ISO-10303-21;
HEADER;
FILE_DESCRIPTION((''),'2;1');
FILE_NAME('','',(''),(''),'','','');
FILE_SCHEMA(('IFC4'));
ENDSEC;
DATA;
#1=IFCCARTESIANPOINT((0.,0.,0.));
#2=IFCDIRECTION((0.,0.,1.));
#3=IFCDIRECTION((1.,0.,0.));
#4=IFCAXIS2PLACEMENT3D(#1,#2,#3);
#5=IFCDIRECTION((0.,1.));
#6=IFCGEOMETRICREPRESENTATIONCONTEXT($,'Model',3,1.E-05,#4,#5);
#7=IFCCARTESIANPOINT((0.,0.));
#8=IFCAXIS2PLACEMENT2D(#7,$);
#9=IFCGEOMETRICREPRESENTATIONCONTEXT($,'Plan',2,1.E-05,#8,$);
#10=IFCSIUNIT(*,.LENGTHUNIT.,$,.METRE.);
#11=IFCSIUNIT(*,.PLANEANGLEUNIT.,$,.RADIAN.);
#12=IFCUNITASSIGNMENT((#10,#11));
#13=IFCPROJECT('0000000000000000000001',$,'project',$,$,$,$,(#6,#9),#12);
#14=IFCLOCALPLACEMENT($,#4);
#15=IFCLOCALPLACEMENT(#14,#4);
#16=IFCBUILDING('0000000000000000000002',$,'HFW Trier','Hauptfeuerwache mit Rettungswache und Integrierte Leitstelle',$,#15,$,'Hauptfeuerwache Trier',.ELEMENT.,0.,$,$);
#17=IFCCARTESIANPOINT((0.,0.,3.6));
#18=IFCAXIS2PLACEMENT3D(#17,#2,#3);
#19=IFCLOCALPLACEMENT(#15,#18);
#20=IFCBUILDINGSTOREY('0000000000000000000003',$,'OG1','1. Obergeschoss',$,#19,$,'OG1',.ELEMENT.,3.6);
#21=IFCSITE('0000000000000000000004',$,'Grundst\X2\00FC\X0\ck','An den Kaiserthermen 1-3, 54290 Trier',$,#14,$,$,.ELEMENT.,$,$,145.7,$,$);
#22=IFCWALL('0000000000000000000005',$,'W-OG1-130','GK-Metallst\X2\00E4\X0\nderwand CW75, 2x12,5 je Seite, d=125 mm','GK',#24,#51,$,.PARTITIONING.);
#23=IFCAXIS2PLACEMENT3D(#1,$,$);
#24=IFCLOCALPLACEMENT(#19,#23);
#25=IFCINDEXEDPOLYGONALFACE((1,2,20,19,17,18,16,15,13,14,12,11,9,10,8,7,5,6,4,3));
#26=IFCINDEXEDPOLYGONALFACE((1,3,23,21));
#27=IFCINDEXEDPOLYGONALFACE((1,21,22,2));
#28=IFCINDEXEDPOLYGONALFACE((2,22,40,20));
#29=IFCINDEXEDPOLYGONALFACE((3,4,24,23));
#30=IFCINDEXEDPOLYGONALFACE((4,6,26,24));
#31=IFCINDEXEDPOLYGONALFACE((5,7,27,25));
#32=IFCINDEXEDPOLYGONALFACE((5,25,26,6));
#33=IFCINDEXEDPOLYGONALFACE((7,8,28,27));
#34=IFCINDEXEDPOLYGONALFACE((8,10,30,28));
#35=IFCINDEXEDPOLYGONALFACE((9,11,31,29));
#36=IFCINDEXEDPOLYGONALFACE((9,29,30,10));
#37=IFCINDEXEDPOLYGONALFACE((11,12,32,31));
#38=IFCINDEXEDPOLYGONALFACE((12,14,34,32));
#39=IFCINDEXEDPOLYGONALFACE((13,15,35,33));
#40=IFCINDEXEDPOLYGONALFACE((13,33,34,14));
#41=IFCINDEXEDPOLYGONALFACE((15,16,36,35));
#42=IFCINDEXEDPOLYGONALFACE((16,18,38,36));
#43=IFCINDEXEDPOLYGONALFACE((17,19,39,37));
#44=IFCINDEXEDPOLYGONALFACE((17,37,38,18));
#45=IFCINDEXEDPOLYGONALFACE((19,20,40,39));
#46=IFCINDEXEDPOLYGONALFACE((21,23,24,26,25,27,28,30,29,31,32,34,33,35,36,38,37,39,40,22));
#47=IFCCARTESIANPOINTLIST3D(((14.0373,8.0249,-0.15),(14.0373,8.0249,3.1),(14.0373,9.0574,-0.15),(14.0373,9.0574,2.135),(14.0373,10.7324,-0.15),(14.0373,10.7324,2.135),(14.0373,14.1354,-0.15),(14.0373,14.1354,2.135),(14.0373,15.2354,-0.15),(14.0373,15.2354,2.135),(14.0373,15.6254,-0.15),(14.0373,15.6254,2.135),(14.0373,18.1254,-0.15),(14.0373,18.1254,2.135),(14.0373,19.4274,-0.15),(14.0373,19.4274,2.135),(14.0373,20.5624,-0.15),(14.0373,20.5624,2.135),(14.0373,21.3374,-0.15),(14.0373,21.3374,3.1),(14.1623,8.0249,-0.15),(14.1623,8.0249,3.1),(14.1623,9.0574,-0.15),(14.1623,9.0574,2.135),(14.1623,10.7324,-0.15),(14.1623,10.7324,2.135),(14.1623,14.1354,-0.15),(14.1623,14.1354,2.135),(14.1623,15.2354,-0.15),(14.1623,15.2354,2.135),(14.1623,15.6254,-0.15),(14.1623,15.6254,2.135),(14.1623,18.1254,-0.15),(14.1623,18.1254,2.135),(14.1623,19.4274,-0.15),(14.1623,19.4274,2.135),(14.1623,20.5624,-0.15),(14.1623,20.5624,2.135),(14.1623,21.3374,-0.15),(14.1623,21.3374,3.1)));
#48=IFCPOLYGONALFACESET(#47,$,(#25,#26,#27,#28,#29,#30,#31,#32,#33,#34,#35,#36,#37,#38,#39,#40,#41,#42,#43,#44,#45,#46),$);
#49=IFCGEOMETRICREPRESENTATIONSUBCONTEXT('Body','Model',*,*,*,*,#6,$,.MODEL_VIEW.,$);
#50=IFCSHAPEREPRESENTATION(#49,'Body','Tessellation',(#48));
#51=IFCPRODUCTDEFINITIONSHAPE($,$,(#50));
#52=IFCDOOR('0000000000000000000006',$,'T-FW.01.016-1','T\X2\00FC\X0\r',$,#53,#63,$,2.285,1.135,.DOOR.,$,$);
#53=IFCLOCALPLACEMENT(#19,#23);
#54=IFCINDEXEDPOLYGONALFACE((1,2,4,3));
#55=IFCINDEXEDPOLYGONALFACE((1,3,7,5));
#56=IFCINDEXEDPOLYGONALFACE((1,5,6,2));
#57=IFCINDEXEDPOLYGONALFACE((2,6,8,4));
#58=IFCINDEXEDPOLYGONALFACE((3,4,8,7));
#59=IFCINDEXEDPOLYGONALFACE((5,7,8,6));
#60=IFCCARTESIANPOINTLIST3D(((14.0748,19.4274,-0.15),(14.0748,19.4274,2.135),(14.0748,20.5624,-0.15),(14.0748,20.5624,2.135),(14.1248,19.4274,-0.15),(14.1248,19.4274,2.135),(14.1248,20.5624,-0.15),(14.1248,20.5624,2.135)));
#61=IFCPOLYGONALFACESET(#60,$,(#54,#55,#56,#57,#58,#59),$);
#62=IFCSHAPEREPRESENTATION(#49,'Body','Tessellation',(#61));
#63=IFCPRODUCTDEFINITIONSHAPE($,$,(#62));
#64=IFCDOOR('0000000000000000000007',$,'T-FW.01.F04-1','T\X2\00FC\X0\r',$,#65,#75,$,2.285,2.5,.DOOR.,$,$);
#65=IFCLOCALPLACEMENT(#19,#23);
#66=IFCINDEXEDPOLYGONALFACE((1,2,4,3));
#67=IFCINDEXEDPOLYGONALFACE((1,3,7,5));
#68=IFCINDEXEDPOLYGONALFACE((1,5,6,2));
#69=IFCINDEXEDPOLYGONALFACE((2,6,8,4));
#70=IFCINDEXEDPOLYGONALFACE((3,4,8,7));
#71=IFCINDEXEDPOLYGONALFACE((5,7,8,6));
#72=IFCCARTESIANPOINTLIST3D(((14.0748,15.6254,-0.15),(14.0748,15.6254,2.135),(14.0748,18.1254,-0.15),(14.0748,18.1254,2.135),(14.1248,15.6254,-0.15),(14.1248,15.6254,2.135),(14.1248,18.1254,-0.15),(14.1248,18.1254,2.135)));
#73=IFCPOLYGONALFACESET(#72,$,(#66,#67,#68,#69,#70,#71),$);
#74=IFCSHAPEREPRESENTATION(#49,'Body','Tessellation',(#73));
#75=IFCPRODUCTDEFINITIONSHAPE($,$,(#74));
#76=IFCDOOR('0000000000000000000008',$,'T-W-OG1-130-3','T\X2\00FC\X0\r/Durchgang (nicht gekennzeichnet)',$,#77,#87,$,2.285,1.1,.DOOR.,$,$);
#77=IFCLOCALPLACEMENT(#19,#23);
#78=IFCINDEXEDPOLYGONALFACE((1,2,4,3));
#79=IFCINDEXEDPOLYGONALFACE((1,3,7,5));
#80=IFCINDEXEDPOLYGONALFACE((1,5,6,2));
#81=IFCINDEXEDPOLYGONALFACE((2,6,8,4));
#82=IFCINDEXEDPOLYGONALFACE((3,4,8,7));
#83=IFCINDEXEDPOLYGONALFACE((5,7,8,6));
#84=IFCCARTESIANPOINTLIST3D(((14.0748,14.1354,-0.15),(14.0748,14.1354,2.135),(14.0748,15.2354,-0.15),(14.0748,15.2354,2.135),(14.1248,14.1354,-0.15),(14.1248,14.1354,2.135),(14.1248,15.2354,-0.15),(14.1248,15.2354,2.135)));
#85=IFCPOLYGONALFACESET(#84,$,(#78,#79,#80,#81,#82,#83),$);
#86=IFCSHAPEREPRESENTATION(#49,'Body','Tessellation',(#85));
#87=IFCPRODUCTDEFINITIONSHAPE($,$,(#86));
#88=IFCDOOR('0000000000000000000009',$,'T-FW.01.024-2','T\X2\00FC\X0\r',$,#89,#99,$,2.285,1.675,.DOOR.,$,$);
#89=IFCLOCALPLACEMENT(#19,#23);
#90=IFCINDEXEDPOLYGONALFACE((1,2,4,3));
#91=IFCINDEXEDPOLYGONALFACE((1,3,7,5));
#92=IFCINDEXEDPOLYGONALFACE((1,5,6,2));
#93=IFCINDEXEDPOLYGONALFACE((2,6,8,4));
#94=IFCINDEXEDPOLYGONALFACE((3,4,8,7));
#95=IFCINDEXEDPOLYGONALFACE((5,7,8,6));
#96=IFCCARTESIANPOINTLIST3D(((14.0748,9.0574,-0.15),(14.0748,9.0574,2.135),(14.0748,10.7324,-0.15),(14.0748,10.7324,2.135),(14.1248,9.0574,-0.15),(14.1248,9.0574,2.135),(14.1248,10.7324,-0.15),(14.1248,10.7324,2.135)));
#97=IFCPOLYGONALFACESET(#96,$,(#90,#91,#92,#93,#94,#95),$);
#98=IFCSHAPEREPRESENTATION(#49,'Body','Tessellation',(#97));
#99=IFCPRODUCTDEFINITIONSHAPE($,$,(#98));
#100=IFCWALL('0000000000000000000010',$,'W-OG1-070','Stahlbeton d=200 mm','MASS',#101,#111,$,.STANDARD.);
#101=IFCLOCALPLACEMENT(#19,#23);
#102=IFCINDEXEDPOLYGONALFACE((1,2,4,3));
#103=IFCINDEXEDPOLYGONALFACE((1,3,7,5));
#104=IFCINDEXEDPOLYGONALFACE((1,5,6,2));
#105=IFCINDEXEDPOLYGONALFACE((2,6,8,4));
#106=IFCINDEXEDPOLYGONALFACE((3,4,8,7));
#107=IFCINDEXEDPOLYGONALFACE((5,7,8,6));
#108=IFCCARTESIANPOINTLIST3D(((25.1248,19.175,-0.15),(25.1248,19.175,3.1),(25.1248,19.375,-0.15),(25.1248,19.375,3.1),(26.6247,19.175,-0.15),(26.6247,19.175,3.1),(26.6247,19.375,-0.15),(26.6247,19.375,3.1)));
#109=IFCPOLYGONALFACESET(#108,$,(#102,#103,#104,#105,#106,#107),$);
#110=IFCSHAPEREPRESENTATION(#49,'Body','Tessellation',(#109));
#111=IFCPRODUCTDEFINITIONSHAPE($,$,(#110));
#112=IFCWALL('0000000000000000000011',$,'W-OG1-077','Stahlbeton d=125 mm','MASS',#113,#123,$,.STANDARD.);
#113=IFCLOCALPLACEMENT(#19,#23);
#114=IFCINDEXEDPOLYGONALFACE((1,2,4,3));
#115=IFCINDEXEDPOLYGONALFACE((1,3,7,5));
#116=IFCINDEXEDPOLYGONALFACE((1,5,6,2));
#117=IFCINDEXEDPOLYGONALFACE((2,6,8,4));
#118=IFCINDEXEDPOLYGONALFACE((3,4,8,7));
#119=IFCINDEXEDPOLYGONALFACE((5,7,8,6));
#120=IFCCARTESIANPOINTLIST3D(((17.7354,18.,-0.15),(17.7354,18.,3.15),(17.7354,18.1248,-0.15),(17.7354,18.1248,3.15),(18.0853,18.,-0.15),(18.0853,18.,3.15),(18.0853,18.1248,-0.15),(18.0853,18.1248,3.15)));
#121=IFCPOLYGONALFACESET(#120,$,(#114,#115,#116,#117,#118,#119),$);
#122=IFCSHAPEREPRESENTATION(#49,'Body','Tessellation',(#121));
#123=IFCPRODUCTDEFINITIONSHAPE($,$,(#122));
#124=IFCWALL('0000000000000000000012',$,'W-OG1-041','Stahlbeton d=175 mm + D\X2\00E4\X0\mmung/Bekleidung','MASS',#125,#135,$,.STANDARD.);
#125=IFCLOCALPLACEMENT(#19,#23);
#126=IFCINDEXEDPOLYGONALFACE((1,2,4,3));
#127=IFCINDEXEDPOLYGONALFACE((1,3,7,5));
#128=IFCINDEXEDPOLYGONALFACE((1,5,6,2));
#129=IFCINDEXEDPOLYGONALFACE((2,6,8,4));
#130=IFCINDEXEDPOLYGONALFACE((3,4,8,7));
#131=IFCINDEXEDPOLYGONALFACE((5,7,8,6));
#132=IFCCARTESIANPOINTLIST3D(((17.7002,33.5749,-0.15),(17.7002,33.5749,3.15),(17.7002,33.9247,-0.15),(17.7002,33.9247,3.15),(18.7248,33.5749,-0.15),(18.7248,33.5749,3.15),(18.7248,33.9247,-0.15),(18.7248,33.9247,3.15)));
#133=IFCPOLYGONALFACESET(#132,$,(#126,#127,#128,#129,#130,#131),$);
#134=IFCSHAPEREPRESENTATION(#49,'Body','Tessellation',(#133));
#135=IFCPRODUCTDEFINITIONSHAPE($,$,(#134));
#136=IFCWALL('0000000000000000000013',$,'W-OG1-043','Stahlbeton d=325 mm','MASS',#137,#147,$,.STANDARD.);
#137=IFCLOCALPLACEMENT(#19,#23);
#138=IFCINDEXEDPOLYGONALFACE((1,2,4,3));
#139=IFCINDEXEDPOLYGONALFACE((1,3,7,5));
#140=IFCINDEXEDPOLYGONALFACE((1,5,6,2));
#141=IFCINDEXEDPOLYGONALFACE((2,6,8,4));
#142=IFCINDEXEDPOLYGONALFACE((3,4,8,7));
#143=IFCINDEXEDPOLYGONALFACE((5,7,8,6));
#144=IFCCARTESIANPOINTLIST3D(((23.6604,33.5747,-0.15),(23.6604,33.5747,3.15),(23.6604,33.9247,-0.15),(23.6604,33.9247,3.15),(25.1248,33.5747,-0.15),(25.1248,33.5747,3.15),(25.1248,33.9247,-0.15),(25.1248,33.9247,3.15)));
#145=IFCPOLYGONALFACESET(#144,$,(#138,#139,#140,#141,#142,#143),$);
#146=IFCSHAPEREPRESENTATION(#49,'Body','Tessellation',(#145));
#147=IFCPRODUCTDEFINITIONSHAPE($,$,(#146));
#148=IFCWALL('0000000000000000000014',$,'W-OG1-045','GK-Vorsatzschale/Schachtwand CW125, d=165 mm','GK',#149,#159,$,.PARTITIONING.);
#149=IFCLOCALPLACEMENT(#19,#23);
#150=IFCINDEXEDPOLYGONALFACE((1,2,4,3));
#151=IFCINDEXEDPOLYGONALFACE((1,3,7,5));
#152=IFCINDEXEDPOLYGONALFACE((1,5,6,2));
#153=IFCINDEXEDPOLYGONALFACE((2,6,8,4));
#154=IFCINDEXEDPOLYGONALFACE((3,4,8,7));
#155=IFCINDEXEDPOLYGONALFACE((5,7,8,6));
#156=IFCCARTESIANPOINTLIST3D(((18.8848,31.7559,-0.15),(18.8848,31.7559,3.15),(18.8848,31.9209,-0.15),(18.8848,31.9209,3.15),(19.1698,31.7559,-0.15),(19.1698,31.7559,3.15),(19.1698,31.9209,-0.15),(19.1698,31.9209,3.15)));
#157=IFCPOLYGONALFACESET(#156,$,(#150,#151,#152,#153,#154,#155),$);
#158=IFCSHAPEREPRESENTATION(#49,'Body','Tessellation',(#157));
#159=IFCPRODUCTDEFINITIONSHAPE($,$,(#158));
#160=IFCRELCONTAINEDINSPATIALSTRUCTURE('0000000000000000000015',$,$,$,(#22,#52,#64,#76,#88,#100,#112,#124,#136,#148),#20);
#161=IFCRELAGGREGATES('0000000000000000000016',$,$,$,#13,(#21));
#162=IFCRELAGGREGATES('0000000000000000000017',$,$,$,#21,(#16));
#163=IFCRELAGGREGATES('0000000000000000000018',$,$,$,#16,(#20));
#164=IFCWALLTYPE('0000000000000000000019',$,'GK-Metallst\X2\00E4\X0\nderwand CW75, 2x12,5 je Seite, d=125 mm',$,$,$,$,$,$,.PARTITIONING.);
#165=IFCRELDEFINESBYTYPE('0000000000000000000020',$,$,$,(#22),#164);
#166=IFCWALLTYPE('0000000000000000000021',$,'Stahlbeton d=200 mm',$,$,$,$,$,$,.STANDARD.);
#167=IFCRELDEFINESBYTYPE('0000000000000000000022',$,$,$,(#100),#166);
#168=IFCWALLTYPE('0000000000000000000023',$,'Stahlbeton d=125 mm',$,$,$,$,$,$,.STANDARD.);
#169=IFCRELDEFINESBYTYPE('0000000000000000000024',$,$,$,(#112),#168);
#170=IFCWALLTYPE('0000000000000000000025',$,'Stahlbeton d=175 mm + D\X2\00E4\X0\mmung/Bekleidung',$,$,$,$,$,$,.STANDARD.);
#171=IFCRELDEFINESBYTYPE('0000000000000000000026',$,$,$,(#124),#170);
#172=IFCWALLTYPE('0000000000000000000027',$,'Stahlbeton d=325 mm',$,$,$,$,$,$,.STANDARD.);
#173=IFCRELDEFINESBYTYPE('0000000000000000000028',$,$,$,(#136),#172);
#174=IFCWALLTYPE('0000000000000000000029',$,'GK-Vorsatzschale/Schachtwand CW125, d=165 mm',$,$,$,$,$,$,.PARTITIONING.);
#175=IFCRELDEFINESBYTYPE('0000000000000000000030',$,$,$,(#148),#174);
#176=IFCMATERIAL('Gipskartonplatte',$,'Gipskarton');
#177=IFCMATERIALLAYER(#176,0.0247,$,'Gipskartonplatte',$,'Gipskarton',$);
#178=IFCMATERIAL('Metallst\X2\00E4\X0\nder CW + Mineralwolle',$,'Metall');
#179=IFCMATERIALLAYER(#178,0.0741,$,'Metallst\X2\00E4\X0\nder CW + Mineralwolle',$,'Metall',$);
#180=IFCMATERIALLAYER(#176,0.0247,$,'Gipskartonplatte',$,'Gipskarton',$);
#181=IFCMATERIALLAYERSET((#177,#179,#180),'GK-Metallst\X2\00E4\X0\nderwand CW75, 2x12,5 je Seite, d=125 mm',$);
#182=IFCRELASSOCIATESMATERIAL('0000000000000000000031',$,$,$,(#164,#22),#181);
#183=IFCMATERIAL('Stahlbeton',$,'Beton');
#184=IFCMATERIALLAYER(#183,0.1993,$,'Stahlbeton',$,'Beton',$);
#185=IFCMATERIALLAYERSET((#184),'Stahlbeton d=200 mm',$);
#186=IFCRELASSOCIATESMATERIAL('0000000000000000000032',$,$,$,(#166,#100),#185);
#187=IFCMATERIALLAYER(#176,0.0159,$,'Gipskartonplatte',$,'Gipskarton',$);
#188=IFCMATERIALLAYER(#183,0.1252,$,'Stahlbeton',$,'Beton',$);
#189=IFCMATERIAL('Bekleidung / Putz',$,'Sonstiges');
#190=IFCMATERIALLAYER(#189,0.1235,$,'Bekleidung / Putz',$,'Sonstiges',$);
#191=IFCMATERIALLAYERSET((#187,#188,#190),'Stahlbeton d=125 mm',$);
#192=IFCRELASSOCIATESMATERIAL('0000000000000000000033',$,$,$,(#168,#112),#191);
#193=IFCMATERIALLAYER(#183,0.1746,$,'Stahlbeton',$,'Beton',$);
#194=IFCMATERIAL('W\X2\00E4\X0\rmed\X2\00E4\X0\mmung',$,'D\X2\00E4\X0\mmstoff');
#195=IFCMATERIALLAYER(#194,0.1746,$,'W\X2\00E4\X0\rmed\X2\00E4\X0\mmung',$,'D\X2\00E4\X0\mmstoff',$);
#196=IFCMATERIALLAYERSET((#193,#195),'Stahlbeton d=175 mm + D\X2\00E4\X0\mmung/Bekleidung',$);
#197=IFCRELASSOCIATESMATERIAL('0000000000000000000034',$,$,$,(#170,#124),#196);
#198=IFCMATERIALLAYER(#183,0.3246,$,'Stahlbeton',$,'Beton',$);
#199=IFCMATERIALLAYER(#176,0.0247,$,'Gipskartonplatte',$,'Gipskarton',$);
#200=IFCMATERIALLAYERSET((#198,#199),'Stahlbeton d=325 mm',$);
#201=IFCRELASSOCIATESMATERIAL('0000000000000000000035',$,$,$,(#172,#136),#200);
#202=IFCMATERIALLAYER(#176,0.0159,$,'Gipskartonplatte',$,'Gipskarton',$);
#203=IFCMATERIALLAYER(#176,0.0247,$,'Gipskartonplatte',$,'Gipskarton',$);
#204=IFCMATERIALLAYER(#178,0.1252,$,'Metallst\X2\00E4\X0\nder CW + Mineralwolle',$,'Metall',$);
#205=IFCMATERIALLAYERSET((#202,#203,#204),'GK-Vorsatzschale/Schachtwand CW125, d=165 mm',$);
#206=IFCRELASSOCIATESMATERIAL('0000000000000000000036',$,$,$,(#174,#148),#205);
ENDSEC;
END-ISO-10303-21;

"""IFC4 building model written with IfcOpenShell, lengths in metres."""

from ifc_helpers import new_model, si_unit, direction, frame, frame_2d, origin_with_axes, origin_2d, place, context, subcontext, project, spatial, rectangle, extrude, material, layer, layer_set, layer_usage, type_object, element, fill, save


model = new_model("IFC4")

# Units and contexts
model_context = context("Model", 3, precision=1e-05, world=origin_with_axes(), true_north=direction((0.0, 1.0)))
plan_context = context("Plan", 2, precision=1e-05, world=origin_2d())
body_context = subcontext(model_context, "Body", "Model", "MODEL_VIEW")
ifc_project = project(units=[si_unit("LENGTHUNIT", "METRE"), si_unit("PLANEANGLEUNIT", "RADIAN")], contexts=[model_context, plan_context])

# Site, building, storey
site_placement = place(None, origin_with_axes())
site = spatial("IfcSite", under=ifc_project, at=site_placement, Name="Grundstück", Description="An den Kaiserthermen 1-3, 54290 Trier", CompositionType="ELEMENT", RefElevation=145.7)
building_placement = place(site_placement, origin_with_axes())
building = spatial("IfcBuilding", under=site, at=building_placement, Name="HFW Trier", Description="Hauptfeuerwache mit Rettungswache und Integrierte Leitstelle", LongName="Hauptfeuerwache Trier", CompositionType="ELEMENT", ElevationOfRefHeight=0.0)
storey_placement = place(building_placement, frame((0.0, 0.0, 3.6), z_axis=(0.0, 0.0, 1.0), x_axis=(1.0, 0.0, 0.0)))
storey = spatial("IfcBuildingStorey", under=building, at=storey_placement, Name="OG1", Description="1. Obergeschoss", LongName="OG1", CompositionType="ELEMENT", Elevation=3.6)

# Shared definitions
ifc_material_1 = material(Name="Stahlbeton", Category="Beton")

# Wall, openings, doors
ifc_material_2 = material(Name="Gipskartonplatte", Category="Gipskarton")
ifc_layer_1 = layer(ifc_material_2, 0.0247, Name="Gipskartonplatte", Category="Gipskarton")
ifc_material_3 = material(Name="Metallständer CW + Mineralwolle", Category="Metall")
ifc_layer_2 = layer(ifc_material_3, 0.0741, Name="Metallständer CW + Mineralwolle", Category="Metall")
ifc_layer_3 = layer(ifc_material_2, 0.0247, Name="Gipskartonplatte", Category="Gipskarton")
ifc_layer_set_1 = layer_set([ifc_layer_1, ifc_layer_2, ifc_layer_3], Name="GK-Metallständerwand CW75, 2x12,5 je Seite, d=125 mm")
ifc_layer_usage_1 = layer_usage(ifc_layer_set_1, "AXIS2", "POSITIVE", -0.0625)
wall_type_1 = type_object("IfcWallType", Name="GK-Metallständerwand CW75, 2x12,5 je Seite, d=125 mm", PredefinedType="PARTITIONING", material=ifc_layer_set_1)
wall_1_placement = place(storey_placement, frame((14.0998, 21.3374, -0.15), z_axis=(0.0, 0.0, 1.0), x_axis=(0.0, -1.0, 0.0)))
wall_1 = element("IfcWall", 1, at=wall_1_placement, inside=storey, type_object=wall_type_1, material=ifc_layer_usage_1, Name="W-OG1-130", Description="GK-Metallständerwand CW75, 2x12,5 je Seite, d=125 mm", ObjectType="GK", PredefinedType="PARTITIONING", context=body_context, shape_type="SweptSolid", body=[
    extrude(rectangle(XDim=13.3125, YDim=0.125, at=frame_2d((6.6562, 0.0))), origin_with_axes(), (0.0, 0.0, 1.0), 3.25),
])
opening_1_placement = place(wall_1_placement, frame((0.775, 0.0, 0.0), z_axis=(0.0, 0.0, 1.0), x_axis=(1.0, 0.0, 0.0)))
opening_1 = element("IfcOpeningElement", 2, at=opening_1_placement, cuts=wall_1, PredefinedType="OPENING", context=body_context, shape_type="SweptSolid", body=[
    extrude(rectangle(XDim=1.135, YDim=0.225, at=frame_2d((0.5675, 0.0))), origin_with_axes(), (0.0, 0.0, 1.0), 2.285),
])
opening_2_placement = place(wall_1_placement, frame((3.212, 0.0, 0.0), z_axis=(0.0, 0.0, 1.0), x_axis=(1.0, 0.0, 0.0)))
opening_2 = element("IfcOpeningElement", 3, at=opening_2_placement, cuts=wall_1, PredefinedType="OPENING", context=body_context, shape_type="SweptSolid", body=[
    extrude(rectangle(XDim=2.5, YDim=0.225, at=frame_2d((1.25, 0.0))), origin_with_axes(), (0.0, 0.0, 1.0), 2.285),
])
opening_3_placement = place(wall_1_placement, frame((6.102, 0.0, 0.0), z_axis=(0.0, 0.0, 1.0), x_axis=(1.0, 0.0, 0.0)))
opening_3 = element("IfcOpeningElement", 4, at=opening_3_placement, cuts=wall_1, PredefinedType="OPENING", context=body_context, shape_type="SweptSolid", body=[
    extrude(rectangle(XDim=1.1, YDim=0.225, at=frame_2d((0.55, 0.0))), origin_with_axes(), (0.0, 0.0, 1.0), 2.285),
])
opening_4_placement = place(wall_1_placement, frame((10.605, 0.0, 0.0), z_axis=(0.0, 0.0, 1.0), x_axis=(1.0, 0.0, 0.0)))
opening_4 = element("IfcOpeningElement", 5, at=opening_4_placement, cuts=wall_1, PredefinedType="OPENING", context=body_context, shape_type="SweptSolid", body=[
    extrude(rectangle(XDim=1.675, YDim=0.225, at=frame_2d((0.8375, 0.0))), origin_with_axes(), (0.0, 0.0, 1.0), 2.285),
])
door_1_placement = place(wall_1_placement, frame((0.775, 0.0, 0.0), z_axis=(0.0, 0.0, 1.0), x_axis=(1.0, 0.0, 0.0)))
door_1 = element("IfcDoor", 6, at=door_1_placement, inside=storey, Name="T-FW.01.016-1", Description="Tür", OverallHeight=2.285, OverallWidth=1.135, PredefinedType="DOOR", context=body_context, shape_type="SweptSolid", body=[
    extrude(rectangle(XDim=1.135, YDim=0.05, at=frame_2d((0.5675, 0.0))), origin_with_axes(), (0.0, 0.0, 1.0), 2.285),
])
fill(opening_1, door_1)
door_2_placement = place(wall_1_placement, frame((3.212, 0.0, 0.0), z_axis=(0.0, 0.0, 1.0), x_axis=(1.0, 0.0, 0.0)))
door_2 = element("IfcDoor", 7, at=door_2_placement, inside=storey, Name="T-FW.01.F04-1", Description="Tür", OverallHeight=2.285, OverallWidth=2.5, PredefinedType="DOOR", context=body_context, shape_type="SweptSolid", body=[
    extrude(rectangle(XDim=2.5, YDim=0.05, at=frame_2d((1.25, 0.0))), origin_with_axes(), (0.0, 0.0, 1.0), 2.285),
])
fill(opening_2, door_2)
door_3_placement = place(wall_1_placement, frame((6.102, 0.0, 0.0), z_axis=(0.0, 0.0, 1.0), x_axis=(1.0, 0.0, 0.0)))
door_3 = element("IfcDoor", 8, at=door_3_placement, inside=storey, Name="T-W-OG1-130-3", Description="Tür/Durchgang (nicht gekennzeichnet)", OverallHeight=2.285, OverallWidth=1.1, PredefinedType="DOOR", context=body_context, shape_type="SweptSolid", body=[
    extrude(rectangle(XDim=1.1, YDim=0.05, at=frame_2d((0.55, 0.0))), origin_with_axes(), (0.0, 0.0, 1.0), 2.285),
])
fill(opening_3, door_3)
door_4_placement = place(wall_1_placement, frame((10.605, 0.0, 0.0), z_axis=(0.0, 0.0, 1.0), x_axis=(1.0, 0.0, 0.0)))
door_4 = element("IfcDoor", 9, at=door_4_placement, inside=storey, Name="T-FW.01.024-2", Description="Tür", OverallHeight=2.285, OverallWidth=1.675, PredefinedType="DOOR", context=body_context, shape_type="SweptSolid", body=[
    extrude(rectangle(XDim=1.675, YDim=0.05, at=frame_2d((0.8375, 0.0))), origin_with_axes(), (0.0, 0.0, 1.0), 2.285),
])
fill(opening_4, door_4)

# Walls
ifc_layer_4 = layer(ifc_material_1, 0.1993, Name="Stahlbeton", Category="Beton")
ifc_layer_set_2 = layer_set([ifc_layer_4], Name="Stahlbeton d=200 mm")
ifc_layer_usage_2 = layer_usage(ifc_layer_set_2, "AXIS2", "POSITIVE", -0.1)
wall_type_2 = type_object("IfcWallType", Name="Stahlbeton d=200 mm", PredefinedType="STANDARD", material=ifc_layer_set_2)
wall_2_placement = place(storey_placement, frame((25.1248, 19.275, -0.15), z_axis=(0.0, 0.0, 1.0), x_axis=(1.0, 0.0, 0.0)))
element("IfcWall", 10, at=wall_2_placement, inside=storey, type_object=wall_type_2, material=ifc_layer_usage_2, Name="W-OG1-070", Description="Stahlbeton d=200 mm", ObjectType="MASS", PredefinedType="STANDARD", context=body_context, shape_type="SweptSolid", body=[
    extrude(rectangle(XDim=1.4999, YDim=0.2, at=frame_2d((0.75, 0.0))), origin_with_axes(), (0.0, 0.0, 1.0), 3.25),
])
ifc_layer_5 = layer(ifc_material_2, 0.0159, Name="Gipskartonplatte", Category="Gipskarton")
ifc_layer_6 = layer(ifc_material_1, 0.1252, Name="Stahlbeton", Category="Beton")
ifc_material_4 = material(Name="Bekleidung / Putz", Category="Sonstiges")
ifc_layer_7 = layer(ifc_material_4, 0.1235, Name="Bekleidung / Putz", Category="Sonstiges")
ifc_layer_set_3 = layer_set([ifc_layer_5, ifc_layer_6, ifc_layer_7], Name="Stahlbeton d=125 mm")
ifc_layer_usage_3 = layer_usage(ifc_layer_set_3, "AXIS2", "POSITIVE", -0.0624)
wall_type_3 = type_object("IfcWallType", Name="Stahlbeton d=125 mm", PredefinedType="STANDARD", material=ifc_layer_set_3)
wall_3_placement = place(storey_placement, frame((17.7354, 18.0624, -0.15), z_axis=(0.0, 0.0, 1.0), x_axis=(1.0, 0.0, 0.0)))
element("IfcWall", 11, at=wall_3_placement, inside=storey, type_object=wall_type_3, material=ifc_layer_usage_3, Name="W-OG1-077", Description="Stahlbeton d=125 mm", ObjectType="MASS", PredefinedType="STANDARD", context=body_context, shape_type="SweptSolid", body=[
    extrude(rectangle(XDim=0.3499, YDim=0.1249, at=frame_2d((0.175, 0.0))), origin_with_axes(), (0.0, 0.0, 1.0), 3.3),
])
ifc_layer_8 = layer(ifc_material_1, 0.1746, Name="Stahlbeton", Category="Beton")
ifc_material_5 = material(Name="Wärmedämmung", Category="Dämmstoff")
ifc_layer_9 = layer(ifc_material_5, 0.1746, Name="Wärmedämmung", Category="Dämmstoff")
ifc_layer_set_4 = layer_set([ifc_layer_8, ifc_layer_9], Name="Stahlbeton d=175 mm + Dämmung/Bekleidung")
ifc_layer_usage_4 = layer_usage(ifc_layer_set_4, "AXIS2", "POSITIVE", -0.1749)
wall_type_4 = type_object("IfcWallType", Name="Stahlbeton d=175 mm + Dämmung/Bekleidung", PredefinedType="STANDARD", material=ifc_layer_set_4)
wall_4_placement = place(storey_placement, frame((17.7002, 33.7498, -0.15), z_axis=(0.0, 0.0, 1.0), x_axis=(1.0, 0.0, 0.0)))
element("IfcWall", 12, at=wall_4_placement, inside=storey, type_object=wall_type_4, material=ifc_layer_usage_4, Name="W-OG1-041", Description="Stahlbeton d=175 mm + Dämmung/Bekleidung", ObjectType="MASS", PredefinedType="STANDARD", context=body_context, shape_type="SweptSolid", body=[
    extrude(rectangle(XDim=1.0246, YDim=0.3498, at=frame_2d((0.5123, 0.0))), origin_with_axes(), (0.0, 0.0, 1.0), 3.3),
])
ifc_layer_10 = layer(ifc_material_1, 0.3246, Name="Stahlbeton", Category="Beton")
ifc_layer_11 = layer(ifc_material_2, 0.0247, Name="Gipskartonplatte", Category="Gipskarton")
ifc_layer_set_5 = layer_set([ifc_layer_10, ifc_layer_11], Name="Stahlbeton d=325 mm")
ifc_layer_usage_5 = layer_usage(ifc_layer_set_5, "AXIS2", "POSITIVE", -0.175)
wall_type_5 = type_object("IfcWallType", Name="Stahlbeton d=325 mm", PredefinedType="STANDARD", material=ifc_layer_set_5)
wall_5_placement = place(storey_placement, frame((23.6604, 33.7497, -0.15), z_axis=(0.0, 0.0, 1.0), x_axis=(1.0, 0.0, 0.0)))
element("IfcWall", 13, at=wall_5_placement, inside=storey, type_object=wall_type_5, material=ifc_layer_usage_5, Name="W-OG1-043", Description="Stahlbeton d=325 mm", ObjectType="MASS", PredefinedType="STANDARD", context=body_context, shape_type="SweptSolid", body=[
    extrude(rectangle(XDim=1.4644, YDim=0.35, at=frame_2d((0.7322, 0.0))), origin_with_axes(), (0.0, 0.0, 1.0), 3.3),
])
ifc_layer_12 = layer(ifc_material_2, 0.0159, Name="Gipskartonplatte", Category="Gipskarton")
ifc_layer_13 = layer(ifc_material_2, 0.0247, Name="Gipskartonplatte", Category="Gipskarton")
ifc_layer_14 = layer(ifc_material_3, 0.1252, Name="Metallständer CW + Mineralwolle", Category="Metall")
ifc_layer_set_6 = layer_set([ifc_layer_12, ifc_layer_13, ifc_layer_14], Name="GK-Vorsatzschale/Schachtwand CW125, d=165 mm")
ifc_layer_usage_6 = layer_usage(ifc_layer_set_6, "AXIS2", "POSITIVE", -0.0825)
wall_type_6 = type_object("IfcWallType", Name="GK-Vorsatzschale/Schachtwand CW125, d=165 mm", PredefinedType="PARTITIONING", material=ifc_layer_set_6)
wall_6_placement = place(storey_placement, frame((18.8848, 31.8384, -0.15), z_axis=(0.0, 0.0, 1.0), x_axis=(1.0, 0.0, 0.0)))
element("IfcWall", 14, at=wall_6_placement, inside=storey, type_object=wall_type_6, material=ifc_layer_usage_6, Name="W-OG1-045", Description="GK-Vorsatzschale/Schachtwand CW125, d=165 mm", ObjectType="GK", PredefinedType="PARTITIONING", context=body_context, shape_type="SweptSolid", body=[
    extrude(rectangle(XDim=0.285, YDim=0.165, at=frame_2d((0.1425, 0.0))), origin_with_axes(), (0.0, 0.0, 1.0), 3.3),
])

save(model, "model.ifc")
